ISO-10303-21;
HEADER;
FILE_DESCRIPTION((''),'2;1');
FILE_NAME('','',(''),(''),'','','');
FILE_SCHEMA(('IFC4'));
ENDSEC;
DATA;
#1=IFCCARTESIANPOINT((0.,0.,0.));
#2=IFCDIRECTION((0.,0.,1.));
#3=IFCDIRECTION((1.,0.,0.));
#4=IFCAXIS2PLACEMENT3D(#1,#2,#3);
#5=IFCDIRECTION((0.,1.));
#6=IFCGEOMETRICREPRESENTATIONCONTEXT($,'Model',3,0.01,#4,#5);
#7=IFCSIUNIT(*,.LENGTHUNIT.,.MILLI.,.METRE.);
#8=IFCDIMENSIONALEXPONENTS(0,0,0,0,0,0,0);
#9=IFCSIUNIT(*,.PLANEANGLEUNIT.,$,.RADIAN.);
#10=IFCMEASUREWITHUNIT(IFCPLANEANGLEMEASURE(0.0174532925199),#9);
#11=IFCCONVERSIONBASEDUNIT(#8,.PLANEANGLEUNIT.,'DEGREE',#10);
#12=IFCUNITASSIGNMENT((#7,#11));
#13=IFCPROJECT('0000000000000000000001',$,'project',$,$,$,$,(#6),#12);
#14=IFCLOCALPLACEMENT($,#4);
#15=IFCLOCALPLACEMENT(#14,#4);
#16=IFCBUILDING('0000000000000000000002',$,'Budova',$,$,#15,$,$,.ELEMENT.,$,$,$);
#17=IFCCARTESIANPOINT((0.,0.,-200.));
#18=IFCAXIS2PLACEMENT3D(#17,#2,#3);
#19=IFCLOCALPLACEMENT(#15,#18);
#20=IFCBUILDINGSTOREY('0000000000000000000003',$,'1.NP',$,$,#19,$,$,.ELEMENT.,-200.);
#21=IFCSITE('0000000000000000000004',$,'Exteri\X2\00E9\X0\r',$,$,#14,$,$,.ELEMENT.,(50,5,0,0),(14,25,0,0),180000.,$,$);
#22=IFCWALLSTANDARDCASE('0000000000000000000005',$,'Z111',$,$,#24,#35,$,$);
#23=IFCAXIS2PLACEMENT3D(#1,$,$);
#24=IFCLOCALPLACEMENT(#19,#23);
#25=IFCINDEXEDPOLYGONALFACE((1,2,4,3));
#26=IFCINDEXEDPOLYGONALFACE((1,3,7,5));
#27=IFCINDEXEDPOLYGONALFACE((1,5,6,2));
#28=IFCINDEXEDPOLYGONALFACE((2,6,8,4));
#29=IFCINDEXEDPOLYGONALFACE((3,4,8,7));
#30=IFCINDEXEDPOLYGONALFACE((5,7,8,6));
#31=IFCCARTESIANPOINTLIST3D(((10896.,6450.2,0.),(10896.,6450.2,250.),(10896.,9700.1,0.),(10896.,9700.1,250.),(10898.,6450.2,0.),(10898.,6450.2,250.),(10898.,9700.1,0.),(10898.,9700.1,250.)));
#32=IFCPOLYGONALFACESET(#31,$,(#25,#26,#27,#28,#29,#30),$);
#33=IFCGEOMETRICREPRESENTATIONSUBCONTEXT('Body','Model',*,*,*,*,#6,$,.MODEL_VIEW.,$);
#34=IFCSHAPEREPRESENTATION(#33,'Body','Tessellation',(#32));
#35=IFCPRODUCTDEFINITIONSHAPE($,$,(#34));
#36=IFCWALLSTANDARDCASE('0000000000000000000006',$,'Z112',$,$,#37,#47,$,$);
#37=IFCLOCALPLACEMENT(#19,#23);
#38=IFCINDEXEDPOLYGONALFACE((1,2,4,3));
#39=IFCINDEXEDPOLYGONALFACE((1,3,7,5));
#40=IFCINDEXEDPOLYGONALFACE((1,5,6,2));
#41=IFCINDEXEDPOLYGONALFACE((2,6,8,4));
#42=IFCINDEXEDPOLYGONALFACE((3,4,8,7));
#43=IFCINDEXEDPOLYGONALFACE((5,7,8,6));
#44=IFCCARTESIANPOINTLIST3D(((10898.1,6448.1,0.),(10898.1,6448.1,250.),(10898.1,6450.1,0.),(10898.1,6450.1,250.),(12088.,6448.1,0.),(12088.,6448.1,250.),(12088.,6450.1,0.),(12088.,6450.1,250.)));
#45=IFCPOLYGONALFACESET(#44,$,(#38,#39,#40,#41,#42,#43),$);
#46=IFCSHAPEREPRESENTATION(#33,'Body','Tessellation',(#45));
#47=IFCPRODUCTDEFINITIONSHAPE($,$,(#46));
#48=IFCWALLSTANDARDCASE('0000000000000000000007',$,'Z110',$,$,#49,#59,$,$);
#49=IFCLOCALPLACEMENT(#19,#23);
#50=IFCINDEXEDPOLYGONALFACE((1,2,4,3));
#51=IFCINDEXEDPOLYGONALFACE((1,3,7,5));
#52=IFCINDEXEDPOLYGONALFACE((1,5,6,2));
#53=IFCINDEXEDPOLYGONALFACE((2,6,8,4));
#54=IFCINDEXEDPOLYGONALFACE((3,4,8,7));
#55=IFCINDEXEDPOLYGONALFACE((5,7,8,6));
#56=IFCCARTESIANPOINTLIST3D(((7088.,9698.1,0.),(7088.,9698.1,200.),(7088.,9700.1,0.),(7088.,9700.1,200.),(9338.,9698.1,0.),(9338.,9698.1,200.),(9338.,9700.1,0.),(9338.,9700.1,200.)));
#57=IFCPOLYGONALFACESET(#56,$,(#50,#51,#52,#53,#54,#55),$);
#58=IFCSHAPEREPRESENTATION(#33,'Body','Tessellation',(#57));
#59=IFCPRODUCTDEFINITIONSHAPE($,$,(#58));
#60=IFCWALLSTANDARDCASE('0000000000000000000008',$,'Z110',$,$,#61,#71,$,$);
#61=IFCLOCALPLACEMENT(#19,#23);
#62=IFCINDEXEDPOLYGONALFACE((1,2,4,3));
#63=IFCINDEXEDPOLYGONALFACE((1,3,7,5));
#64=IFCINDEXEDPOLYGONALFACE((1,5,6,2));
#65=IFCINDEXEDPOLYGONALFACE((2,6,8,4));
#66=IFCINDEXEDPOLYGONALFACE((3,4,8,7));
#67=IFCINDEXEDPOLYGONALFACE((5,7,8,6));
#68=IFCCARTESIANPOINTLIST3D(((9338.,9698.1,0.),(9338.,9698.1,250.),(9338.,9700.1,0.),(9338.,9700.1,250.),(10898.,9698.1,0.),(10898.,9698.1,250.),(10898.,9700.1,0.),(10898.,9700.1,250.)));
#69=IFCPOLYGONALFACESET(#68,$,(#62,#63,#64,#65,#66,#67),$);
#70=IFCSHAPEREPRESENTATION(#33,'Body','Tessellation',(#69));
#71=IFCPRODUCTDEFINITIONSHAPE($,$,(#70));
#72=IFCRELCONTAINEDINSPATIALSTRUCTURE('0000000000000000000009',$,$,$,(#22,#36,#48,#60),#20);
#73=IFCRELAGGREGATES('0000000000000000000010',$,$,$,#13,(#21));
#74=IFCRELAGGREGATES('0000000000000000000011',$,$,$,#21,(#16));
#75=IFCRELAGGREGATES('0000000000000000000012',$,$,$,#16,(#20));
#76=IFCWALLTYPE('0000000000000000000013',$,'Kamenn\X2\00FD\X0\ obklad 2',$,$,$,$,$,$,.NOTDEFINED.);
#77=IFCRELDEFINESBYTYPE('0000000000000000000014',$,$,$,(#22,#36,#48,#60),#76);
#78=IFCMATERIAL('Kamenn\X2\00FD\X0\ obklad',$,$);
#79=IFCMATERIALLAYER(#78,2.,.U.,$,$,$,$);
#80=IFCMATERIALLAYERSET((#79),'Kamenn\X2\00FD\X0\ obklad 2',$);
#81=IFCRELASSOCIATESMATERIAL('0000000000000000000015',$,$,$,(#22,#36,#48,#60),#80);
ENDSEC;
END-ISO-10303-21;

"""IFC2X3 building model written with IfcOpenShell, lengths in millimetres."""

from ifc_helpers import new_model, entity, si_unit, converted_unit, direction, frame, origin_with_axes, place, context, subcontext, project, spatial, polyline, outline, extrude, material, layer, layer_set, layer_usage, type_object, element, save


model = new_model("IFC2X3")

# Units and contexts
model_context = context("Model", 3, precision=0.01, world=origin_with_axes(), true_north=direction((0.0, 1.0)))
body_context = subcontext(model_context, "Body", "Model", "MODEL_VIEW")
ifc_project = project(units=[si_unit("LENGTHUNIT", "METRE", prefix="MILLI"), converted_unit("PLANEANGLEUNIT", "DEGREE", entity("IfcPlaneAngleMeasure", 0.0174532925199), si_unit("PLANEANGLEUNIT", "RADIAN"), dimensions=[0, 0, 0, 0, 0, 0, 0])], contexts=[model_context])

# Site, building, storey
site_placement = place(None, origin_with_axes())
site = spatial("IfcSite", under=ifc_project, at=site_placement, Name="Exteriér", CompositionType="ELEMENT", RefLatitude=(50, 5, 0, 0), RefLongitude=(14, 25, 0, 0), RefElevation=180000.0)
building_placement = place(site_placement, origin_with_axes())
building = spatial("IfcBuilding", under=site, at=building_placement, Name="Budova", CompositionType="ELEMENT")
storey_placement = place(building_placement, frame((0.0, 0.0, -200.0), z_axis=(0.0, 0.0, 1.0), x_axis=(1.0, 0.0, 0.0)))
storey = spatial("IfcBuildingStorey", under=building, at=storey_placement, Name="1.NP", CompositionType="ELEMENT", Elevation=-200.0)

# Walls
ifc_material_1 = material(Name="Kamenný obklad")
ifc_layer_1 = layer(ifc_material_1, 2.0, ventilated="UNKNOWN")
ifc_layer_set_1 = layer_set([ifc_layer_1], Name="Kamenný obklad 2")
wall_type_1 = type_object("IfcWallType", Name="Kamenný obklad 2", PredefinedType="NOTDEFINED")
ifc_layer_usage_1 = layer_usage(ifc_layer_set_1, "AXIS2", "POSITIVE", -2.0)
wall_1_placement = place(storey_placement, frame((10898.0, 9700.1, 0.0), z_axis=(0.0, 0.0, 1.0), x_axis=(0.0, -1.0, 0.0)))
element("IfcWallStandardCase", 1, at=wall_1_placement, inside=storey, type_object=wall_type_1, material=ifc_layer_usage_1, Name="Z111", context=body_context, shape_type="SweptSolid", body=[
    extrude(outline(polyline([(0.0, -2.0), (3249.9, -2.0), (3249.9, 0.0), (0.0, 0.0), (0.0, -2.0)])), origin_with_axes(), (0.0, 0.0, 1.0), 250.0),
])
ifc_layer_usage_2 = layer_usage(ifc_layer_set_1, "AXIS2", "POSITIVE", -2.0)
wall_2_placement = place(storey_placement, frame((10898.1, 6450.1, 0.0), z_axis=(0.0, 0.0, 1.0), x_axis=(1.0, 0.0, 0.0)))
element("IfcWallStandardCase", 2, at=wall_2_placement, inside=storey, type_object=wall_type_1, material=ifc_layer_usage_2, Name="Z112", context=body_context, shape_type="SweptSolid", body=[
    extrude(outline(polyline([(0.0, -2.0), (1189.9, -2.0), (1189.9, 0.0), (0.0, 0.0), (0.0, -2.0)])), origin_with_axes(), (0.0, 0.0, 1.0), 250.0),
])
ifc_layer_usage_3 = layer_usage(ifc_layer_set_1, "AXIS2", "POSITIVE", -2.0)
wall_3_placement = place(storey_placement, frame((7088.0, 9700.1, 0.0), z_axis=(0.0, 0.0, 1.0), x_axis=(1.0, 0.0, 0.0)))
element("IfcWallStandardCase", 3, at=wall_3_placement, inside=storey, type_object=wall_type_1, material=ifc_layer_usage_3, Name="Z110", context=body_context, shape_type="SweptSolid", body=[
    extrude(outline(polyline([(0.0, -2.0), (2250.0, -2.0), (2250.0, 0.0), (0.0, 0.0), (0.0, -2.0)])), origin_with_axes(), (0.0, 0.0, 1.0), 200.0),
])
ifc_layer_usage_4 = layer_usage(ifc_layer_set_1, "AXIS2", "POSITIVE", -2.0)
wall_4_placement = place(storey_placement, frame((9338.0, 9700.1, 0.0), z_axis=(0.0, 0.0, 1.0), x_axis=(1.0, 0.0, 0.0)))
element("IfcWallStandardCase", 4, at=wall_4_placement, inside=storey, type_object=wall_type_1, material=ifc_layer_usage_4, Name="Z110", context=body_context, shape_type="SweptSolid", body=[
    extrude(outline(polyline([(0.0, -2.0), (1560.0, -2.0), (1560.0, 0.0), (0.0, 0.0), (0.0, -2.0)])), origin_with_axes(), (0.0, 0.0, 1.0), 250.0),
])

save(model, "model.ifc")
